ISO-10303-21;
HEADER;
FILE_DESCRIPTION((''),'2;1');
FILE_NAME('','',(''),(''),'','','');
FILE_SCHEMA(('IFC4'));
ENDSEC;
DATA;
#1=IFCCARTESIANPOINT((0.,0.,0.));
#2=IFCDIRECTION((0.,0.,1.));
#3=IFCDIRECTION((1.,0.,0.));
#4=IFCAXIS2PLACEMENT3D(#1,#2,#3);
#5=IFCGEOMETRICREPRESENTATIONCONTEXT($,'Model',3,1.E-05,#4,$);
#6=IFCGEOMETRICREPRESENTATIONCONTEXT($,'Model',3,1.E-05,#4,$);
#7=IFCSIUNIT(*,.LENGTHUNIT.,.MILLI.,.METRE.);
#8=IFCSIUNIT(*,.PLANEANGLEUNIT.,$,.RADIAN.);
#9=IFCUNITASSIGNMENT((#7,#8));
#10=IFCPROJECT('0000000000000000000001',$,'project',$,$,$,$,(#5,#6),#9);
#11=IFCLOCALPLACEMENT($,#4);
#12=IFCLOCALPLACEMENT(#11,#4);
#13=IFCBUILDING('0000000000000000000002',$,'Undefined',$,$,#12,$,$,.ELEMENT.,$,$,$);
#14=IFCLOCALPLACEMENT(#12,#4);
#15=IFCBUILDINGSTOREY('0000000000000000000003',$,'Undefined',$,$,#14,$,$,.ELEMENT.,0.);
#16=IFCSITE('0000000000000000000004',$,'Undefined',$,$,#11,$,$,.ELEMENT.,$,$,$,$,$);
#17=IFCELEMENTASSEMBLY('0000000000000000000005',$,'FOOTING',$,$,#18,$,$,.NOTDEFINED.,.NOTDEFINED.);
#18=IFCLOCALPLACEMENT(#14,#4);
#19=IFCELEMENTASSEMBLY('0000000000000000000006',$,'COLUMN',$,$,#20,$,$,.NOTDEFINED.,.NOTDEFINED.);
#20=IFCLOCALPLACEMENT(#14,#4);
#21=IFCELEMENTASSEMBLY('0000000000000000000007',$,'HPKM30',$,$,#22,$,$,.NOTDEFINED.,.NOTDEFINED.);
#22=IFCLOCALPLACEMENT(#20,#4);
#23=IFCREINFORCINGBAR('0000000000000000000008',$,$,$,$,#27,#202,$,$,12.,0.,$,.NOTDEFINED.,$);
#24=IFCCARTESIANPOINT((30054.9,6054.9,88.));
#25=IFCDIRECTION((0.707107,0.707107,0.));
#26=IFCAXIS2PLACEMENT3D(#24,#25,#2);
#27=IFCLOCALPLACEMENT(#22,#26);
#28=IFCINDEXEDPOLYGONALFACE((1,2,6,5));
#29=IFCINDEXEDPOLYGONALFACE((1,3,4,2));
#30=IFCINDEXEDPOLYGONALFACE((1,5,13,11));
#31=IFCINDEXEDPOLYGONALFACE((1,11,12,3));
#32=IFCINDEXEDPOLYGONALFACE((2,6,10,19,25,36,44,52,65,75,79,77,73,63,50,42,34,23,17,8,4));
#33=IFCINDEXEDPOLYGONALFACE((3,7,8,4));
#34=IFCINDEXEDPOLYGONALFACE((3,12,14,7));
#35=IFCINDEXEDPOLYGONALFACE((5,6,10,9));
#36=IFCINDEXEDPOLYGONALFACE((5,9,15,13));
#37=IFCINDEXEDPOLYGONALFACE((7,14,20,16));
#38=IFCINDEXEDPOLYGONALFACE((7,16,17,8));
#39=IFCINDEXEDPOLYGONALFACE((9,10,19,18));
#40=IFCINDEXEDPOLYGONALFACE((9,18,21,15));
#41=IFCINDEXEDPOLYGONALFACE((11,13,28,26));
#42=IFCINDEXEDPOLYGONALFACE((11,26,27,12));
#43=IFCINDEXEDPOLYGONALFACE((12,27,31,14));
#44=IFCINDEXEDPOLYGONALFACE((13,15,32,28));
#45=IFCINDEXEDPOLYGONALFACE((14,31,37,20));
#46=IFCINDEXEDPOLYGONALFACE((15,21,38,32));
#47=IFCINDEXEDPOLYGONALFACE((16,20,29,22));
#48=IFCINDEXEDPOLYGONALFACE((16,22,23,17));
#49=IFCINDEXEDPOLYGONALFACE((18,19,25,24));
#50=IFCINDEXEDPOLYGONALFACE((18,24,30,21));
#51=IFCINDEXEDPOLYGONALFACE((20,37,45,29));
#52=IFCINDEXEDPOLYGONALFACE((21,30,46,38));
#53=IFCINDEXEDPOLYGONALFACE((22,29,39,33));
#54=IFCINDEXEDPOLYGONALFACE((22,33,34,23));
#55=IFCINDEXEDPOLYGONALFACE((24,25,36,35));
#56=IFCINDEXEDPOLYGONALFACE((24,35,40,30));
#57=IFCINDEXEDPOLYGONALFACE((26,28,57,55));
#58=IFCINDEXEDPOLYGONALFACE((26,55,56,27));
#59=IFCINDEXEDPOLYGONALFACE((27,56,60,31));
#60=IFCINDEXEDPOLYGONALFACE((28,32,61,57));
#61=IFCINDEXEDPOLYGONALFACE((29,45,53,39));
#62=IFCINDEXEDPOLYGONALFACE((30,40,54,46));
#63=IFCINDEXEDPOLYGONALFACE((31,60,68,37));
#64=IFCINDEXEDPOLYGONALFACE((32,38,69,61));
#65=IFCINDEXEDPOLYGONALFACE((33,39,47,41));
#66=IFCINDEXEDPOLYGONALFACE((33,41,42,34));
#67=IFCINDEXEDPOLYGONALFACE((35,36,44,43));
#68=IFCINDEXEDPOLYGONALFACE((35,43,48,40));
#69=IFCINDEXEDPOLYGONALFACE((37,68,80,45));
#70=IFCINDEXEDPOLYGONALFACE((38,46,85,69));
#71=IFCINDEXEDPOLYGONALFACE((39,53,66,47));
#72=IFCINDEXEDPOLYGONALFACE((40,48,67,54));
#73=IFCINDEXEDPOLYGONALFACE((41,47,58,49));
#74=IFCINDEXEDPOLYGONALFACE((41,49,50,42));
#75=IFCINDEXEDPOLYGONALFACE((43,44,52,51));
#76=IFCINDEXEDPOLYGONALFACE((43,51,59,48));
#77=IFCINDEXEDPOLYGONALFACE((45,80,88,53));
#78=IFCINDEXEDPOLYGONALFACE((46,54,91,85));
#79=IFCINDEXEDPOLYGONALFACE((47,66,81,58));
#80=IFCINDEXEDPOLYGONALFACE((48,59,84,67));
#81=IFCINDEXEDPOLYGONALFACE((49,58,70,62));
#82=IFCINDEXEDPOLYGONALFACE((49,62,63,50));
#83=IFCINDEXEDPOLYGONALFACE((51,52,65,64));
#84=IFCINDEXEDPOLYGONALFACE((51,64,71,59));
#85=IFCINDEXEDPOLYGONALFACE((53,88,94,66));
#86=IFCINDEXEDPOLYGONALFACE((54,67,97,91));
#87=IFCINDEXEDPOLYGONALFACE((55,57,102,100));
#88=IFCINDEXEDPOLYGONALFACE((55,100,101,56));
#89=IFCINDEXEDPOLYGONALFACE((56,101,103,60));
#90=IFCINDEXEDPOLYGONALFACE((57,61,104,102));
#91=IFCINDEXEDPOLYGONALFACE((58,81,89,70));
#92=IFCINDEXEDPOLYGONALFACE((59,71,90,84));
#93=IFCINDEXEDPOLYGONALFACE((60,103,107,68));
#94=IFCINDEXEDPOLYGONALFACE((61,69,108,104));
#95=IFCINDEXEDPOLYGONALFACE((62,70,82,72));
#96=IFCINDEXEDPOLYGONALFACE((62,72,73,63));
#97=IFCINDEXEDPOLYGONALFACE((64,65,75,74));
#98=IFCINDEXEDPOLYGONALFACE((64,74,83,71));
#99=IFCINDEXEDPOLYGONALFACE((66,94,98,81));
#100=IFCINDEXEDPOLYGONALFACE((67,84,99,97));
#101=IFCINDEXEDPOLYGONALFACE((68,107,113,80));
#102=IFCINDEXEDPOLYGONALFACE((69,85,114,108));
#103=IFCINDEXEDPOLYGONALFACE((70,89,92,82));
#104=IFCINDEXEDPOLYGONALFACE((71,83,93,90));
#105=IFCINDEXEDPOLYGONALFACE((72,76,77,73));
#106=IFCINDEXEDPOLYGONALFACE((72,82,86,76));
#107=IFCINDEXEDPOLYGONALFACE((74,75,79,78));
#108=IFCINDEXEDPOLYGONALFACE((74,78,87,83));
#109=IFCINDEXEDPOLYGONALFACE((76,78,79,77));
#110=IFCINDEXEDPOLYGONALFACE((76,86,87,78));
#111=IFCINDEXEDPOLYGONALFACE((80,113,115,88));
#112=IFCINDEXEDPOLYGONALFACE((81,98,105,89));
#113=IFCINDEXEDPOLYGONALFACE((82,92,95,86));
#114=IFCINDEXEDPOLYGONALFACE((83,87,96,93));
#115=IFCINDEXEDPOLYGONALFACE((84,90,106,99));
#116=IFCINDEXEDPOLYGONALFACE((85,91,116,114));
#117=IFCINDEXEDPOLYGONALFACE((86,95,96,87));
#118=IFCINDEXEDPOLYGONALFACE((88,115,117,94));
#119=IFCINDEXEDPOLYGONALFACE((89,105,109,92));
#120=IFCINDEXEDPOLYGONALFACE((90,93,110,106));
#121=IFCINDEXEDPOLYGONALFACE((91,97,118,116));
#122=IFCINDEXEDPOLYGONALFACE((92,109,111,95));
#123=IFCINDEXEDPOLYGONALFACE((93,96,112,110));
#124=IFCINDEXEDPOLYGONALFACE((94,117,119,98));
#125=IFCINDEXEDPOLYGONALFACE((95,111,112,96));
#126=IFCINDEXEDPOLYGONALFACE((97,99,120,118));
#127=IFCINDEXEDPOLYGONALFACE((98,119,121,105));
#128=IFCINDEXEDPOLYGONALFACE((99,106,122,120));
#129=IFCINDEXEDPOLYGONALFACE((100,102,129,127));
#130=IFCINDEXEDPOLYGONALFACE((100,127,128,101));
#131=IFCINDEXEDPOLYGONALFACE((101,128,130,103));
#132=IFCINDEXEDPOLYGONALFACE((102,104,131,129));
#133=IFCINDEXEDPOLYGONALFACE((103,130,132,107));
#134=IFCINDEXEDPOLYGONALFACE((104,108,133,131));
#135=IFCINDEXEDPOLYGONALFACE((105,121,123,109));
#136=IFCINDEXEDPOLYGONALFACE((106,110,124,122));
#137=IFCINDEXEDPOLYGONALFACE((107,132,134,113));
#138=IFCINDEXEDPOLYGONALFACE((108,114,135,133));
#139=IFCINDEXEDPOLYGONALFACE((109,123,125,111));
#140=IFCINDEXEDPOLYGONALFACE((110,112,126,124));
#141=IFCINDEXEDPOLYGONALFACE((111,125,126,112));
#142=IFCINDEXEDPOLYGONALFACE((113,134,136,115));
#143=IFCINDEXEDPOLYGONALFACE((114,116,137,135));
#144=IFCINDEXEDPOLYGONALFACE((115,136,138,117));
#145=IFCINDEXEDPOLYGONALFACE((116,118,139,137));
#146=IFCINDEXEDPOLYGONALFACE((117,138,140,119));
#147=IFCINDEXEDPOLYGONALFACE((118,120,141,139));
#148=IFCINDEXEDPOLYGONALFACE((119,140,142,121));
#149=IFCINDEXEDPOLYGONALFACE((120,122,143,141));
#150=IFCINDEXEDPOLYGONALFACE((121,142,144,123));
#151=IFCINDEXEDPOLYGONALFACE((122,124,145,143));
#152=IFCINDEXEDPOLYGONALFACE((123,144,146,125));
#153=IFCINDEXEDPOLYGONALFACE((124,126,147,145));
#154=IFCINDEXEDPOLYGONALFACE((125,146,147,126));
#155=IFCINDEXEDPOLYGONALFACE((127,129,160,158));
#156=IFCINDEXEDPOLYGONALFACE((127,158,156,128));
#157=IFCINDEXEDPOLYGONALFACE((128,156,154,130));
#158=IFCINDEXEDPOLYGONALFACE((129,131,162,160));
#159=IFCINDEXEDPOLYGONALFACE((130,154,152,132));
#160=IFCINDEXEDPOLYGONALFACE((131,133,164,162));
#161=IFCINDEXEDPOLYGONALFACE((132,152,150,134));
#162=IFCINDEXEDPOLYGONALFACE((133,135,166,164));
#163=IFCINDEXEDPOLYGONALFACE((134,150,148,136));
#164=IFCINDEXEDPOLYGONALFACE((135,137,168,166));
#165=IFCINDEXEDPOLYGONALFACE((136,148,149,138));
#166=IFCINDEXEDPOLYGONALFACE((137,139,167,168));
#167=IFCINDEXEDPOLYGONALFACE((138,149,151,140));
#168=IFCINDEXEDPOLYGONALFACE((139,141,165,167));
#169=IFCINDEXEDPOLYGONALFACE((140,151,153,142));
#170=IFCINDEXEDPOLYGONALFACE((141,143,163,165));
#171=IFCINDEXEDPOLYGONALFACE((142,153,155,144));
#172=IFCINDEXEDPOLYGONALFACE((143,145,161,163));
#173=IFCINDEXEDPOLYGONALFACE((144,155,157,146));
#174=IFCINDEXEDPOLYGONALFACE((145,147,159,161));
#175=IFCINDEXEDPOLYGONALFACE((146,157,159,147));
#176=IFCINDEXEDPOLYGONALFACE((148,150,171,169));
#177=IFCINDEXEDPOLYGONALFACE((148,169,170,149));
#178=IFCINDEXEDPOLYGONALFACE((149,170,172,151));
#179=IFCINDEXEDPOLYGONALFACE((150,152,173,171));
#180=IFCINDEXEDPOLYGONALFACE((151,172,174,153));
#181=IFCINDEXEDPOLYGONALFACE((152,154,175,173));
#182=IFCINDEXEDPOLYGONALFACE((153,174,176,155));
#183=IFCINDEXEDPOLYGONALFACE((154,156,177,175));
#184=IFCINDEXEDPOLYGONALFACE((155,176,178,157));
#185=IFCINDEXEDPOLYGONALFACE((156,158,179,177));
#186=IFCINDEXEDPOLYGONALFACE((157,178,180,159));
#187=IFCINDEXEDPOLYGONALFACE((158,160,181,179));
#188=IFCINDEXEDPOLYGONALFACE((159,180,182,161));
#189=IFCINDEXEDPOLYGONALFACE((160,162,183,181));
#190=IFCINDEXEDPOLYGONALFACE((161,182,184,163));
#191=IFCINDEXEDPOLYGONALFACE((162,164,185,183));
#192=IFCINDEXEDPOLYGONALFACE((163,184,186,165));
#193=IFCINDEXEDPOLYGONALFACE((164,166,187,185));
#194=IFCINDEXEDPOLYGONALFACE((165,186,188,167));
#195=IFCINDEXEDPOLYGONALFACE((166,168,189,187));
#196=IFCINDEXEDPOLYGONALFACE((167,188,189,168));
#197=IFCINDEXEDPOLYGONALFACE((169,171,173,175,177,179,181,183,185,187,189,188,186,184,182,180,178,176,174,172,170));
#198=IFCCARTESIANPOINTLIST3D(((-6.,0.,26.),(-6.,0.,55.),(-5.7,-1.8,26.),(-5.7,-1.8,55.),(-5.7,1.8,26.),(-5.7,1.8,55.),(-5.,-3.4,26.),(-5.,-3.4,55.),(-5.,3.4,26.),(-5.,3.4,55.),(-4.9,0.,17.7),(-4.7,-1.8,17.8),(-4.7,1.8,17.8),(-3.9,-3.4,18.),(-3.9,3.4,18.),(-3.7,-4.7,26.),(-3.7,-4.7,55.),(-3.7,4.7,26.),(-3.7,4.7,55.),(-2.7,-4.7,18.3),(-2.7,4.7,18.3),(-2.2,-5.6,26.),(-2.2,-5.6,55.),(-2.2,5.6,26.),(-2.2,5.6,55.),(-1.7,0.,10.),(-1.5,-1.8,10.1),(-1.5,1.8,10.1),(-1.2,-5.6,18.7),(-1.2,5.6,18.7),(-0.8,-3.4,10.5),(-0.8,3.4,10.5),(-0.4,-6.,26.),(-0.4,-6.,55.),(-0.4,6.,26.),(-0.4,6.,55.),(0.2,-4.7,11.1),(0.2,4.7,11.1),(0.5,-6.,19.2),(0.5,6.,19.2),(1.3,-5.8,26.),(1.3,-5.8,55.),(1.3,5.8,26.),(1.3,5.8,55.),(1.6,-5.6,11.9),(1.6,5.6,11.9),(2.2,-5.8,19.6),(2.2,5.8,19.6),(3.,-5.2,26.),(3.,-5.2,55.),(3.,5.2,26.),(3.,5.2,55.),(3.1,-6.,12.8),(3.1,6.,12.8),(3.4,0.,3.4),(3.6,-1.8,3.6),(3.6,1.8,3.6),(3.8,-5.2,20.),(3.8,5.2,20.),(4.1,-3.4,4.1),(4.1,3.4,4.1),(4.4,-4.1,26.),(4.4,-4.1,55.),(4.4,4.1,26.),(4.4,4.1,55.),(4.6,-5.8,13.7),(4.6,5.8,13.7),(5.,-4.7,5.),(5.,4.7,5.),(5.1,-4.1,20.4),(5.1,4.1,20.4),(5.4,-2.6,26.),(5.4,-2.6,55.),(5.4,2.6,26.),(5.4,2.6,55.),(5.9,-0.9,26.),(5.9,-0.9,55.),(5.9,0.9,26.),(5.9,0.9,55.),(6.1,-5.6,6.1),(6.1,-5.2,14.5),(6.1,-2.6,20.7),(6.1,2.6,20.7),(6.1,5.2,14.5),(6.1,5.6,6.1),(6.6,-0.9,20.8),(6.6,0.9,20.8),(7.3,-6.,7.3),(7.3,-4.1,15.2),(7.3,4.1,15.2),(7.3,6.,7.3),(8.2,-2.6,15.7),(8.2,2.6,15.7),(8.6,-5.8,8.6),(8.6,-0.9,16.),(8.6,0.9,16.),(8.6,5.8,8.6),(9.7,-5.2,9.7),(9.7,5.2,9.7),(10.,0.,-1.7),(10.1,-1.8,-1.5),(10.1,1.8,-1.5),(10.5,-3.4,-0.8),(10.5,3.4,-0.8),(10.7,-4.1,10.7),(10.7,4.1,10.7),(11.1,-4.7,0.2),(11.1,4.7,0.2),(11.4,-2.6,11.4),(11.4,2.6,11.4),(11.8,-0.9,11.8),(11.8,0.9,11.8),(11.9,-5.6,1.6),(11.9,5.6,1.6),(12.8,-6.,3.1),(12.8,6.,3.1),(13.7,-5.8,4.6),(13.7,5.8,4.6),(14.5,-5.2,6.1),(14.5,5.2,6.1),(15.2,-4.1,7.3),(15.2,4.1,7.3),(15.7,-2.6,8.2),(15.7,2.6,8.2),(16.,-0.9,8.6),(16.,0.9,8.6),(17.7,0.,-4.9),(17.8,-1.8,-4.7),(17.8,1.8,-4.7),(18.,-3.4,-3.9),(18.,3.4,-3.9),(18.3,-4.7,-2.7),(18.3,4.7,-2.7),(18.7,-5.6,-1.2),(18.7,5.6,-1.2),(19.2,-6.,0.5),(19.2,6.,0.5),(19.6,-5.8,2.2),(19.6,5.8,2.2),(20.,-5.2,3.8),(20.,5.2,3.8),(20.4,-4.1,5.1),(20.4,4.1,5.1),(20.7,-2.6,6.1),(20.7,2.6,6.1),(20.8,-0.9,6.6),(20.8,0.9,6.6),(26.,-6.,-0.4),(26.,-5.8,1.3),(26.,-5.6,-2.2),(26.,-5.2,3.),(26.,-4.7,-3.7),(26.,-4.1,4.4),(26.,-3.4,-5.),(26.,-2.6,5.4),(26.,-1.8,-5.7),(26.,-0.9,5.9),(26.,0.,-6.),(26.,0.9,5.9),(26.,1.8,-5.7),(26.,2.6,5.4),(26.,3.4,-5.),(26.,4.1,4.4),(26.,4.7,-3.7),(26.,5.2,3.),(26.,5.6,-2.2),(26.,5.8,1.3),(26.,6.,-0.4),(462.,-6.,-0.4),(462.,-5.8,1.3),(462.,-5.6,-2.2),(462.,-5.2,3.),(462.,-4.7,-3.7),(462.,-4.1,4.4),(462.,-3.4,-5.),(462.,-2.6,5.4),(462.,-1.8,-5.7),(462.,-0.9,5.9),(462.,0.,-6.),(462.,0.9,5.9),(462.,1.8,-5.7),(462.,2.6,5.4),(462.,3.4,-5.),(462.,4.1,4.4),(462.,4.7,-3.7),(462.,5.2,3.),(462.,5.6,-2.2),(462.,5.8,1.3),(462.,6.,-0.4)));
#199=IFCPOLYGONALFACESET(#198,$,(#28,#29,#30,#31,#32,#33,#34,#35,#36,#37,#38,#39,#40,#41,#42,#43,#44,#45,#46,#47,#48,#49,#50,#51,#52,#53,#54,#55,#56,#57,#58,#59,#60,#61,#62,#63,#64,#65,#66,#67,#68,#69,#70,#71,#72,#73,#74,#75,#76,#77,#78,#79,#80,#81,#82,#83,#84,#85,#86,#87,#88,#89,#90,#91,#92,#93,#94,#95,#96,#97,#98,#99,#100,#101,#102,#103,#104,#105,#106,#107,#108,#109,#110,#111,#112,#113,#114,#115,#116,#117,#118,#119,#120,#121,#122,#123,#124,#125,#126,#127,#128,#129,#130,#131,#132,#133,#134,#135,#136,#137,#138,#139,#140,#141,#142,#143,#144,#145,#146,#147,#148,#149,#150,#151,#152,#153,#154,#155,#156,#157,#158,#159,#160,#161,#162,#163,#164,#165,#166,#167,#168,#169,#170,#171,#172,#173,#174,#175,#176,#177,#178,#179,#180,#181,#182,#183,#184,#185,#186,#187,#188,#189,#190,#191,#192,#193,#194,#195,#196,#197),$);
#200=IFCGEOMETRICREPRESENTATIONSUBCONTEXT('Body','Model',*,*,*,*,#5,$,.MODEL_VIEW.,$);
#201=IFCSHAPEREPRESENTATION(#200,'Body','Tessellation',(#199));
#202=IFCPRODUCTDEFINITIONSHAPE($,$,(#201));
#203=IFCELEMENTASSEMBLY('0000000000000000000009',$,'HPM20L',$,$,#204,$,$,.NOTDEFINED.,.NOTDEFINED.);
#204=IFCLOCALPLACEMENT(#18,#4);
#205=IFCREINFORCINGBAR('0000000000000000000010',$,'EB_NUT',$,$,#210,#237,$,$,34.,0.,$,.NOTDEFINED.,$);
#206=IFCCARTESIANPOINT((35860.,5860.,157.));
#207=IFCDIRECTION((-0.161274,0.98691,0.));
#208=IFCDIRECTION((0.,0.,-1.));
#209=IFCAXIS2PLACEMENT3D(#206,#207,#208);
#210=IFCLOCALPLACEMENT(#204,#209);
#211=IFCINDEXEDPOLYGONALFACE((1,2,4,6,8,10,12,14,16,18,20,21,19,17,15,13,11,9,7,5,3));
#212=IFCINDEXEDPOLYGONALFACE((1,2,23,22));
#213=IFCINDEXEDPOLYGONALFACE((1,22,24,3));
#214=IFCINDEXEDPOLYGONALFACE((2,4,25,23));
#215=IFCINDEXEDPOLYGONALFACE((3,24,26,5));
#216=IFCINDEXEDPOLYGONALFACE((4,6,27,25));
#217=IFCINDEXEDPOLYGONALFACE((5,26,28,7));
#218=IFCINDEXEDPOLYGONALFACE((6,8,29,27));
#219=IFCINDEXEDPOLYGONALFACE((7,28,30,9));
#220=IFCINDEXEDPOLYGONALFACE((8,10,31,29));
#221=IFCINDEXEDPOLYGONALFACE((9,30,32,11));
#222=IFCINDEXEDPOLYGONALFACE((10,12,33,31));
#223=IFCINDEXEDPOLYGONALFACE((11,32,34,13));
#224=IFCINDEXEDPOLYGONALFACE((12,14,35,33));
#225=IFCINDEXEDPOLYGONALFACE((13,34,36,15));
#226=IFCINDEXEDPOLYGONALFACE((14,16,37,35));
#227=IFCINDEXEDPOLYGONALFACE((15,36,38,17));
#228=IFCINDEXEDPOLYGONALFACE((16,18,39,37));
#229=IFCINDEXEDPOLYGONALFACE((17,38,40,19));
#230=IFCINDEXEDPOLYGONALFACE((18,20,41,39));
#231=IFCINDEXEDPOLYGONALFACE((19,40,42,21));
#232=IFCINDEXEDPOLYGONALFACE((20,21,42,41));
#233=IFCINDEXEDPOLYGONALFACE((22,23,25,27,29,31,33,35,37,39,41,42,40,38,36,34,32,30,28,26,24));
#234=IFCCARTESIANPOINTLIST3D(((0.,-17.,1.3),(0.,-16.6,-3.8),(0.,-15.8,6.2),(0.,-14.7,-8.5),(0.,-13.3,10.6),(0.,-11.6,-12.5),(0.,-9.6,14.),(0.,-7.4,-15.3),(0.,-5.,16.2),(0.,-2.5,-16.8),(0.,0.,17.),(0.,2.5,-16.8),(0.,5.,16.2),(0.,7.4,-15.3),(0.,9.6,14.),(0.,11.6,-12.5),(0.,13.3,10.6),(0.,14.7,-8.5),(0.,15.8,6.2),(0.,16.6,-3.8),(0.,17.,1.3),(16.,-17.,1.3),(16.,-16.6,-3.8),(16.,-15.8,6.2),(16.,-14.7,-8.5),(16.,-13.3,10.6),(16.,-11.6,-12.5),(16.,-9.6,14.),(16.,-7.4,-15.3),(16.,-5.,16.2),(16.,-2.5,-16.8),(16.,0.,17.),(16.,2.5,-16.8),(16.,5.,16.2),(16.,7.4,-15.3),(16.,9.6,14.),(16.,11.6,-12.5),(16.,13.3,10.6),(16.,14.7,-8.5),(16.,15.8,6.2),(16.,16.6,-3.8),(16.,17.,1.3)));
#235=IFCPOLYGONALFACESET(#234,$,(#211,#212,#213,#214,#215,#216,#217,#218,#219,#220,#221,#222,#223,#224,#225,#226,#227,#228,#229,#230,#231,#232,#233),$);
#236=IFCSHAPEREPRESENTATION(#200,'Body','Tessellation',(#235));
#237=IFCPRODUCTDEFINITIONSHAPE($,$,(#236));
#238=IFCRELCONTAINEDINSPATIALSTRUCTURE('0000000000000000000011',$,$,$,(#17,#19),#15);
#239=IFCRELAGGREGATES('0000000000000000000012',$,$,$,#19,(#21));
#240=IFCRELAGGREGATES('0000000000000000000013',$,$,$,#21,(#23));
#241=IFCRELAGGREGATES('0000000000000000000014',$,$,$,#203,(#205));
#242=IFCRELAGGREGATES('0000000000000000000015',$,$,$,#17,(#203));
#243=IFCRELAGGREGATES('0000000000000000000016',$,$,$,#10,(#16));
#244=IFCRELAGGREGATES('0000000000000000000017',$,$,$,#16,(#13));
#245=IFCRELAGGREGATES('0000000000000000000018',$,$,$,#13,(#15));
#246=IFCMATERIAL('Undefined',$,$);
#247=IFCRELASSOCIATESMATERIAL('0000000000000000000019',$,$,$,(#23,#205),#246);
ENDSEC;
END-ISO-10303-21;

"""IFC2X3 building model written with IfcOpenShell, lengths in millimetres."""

from ifc_helpers import new_model, entity, si_unit, frame, origin_with_axes, place, context, subcontext, project, spatial, source, transform, mapped, material, element, aggregate, save


model = new_model("IFC2X3")

# Units and contexts
model_context_1 = context("Model", 3, precision=1e-05, world=origin_with_axes())
model_context_2 = context("Model", 3, precision=1e-05, world=origin_with_axes())
body_context = subcontext(model_context_1, "Body", "Model", "MODEL_VIEW")
ifc_project = project(units=[si_unit("LENGTHUNIT", "METRE", prefix="MILLI"), si_unit("PLANEANGLEUNIT", "RADIAN")], contexts=[model_context_1, model_context_2])

# Site, building, storey
site_placement = place(None, origin_with_axes())
site = spatial("IfcSite", under=ifc_project, at=site_placement, Name="Undefined", CompositionType="ELEMENT")
building_placement = place(site_placement, origin_with_axes())
building = spatial("IfcBuilding", under=site, at=building_placement, Name="Undefined", CompositionType="ELEMENT")
storey_placement = place(building_placement, origin_with_axes())
storey = spatial("IfcBuildingStorey", under=building, at=storey_placement, Name="Undefined", CompositionType="ELEMENT", Elevation=0.0)

# Element assembly
assembly_1_placement = place(storey_placement, origin_with_axes())
assembly_1 = element("IfcElementAssembly", 1, at=assembly_1_placement, inside=storey, Name="FOOTING", AssemblyPlace="NOTDEFINED", PredefinedType="NOTDEFINED")

# Element assemblies
assembly_2_placement = place(storey_placement, origin_with_axes())
assembly_2 = element("IfcElementAssembly", 2, at=assembly_2_placement, inside=storey, Name="COLUMN", AssemblyPlace="NOTDEFINED", PredefinedType="NOTDEFINED")
assembly_3_placement = place(assembly_2_placement, origin_with_axes())
assembly_3 = element("IfcElementAssembly", 3, at=assembly_3_placement, Name="HPKM30", AssemblyPlace="NOTDEFINED", PredefinedType="NOTDEFINED")
aggregate(assembly_2, [assembly_3])

# Shared definitions
ifc_material_1 = material(Name="Undefined")

# Reinforcing bar
shared_shape_1 = source(origin_with_axes(), body_context, "Body", "AdvancedSweptSolid", [
    entity("IfcSweptDiskSolid", entity("IfcCompositeCurve", [entity("IfcCompositeCurveSegment", "CONTINUOUS", True, entity("IfcTrimmedCurve", entity("IfcLine", entity("IfcCartesianPoint", [0.0, 0.0, 0.0]), entity("IfcVector", entity("IfcDirection", [0.0, 0.0, -1.0]), 1.0)), [entity("IfcParameterValue", 0.0)], [entity("IfcParameterValue", 29.0)], True, "PARAMETER")), entity("IfcCompositeCurveSegment", "CONTINUOUS", True, entity("IfcTrimmedCurve", entity("IfcCircle", entity("IfcAxis2Placement3D", entity("IfcCartesianPoint", [26.0, 0.0, -29.0]), entity("IfcDirection", [0.0, -1.0, 0.0]), entity("IfcDirection", [-1.0, 0.0, 0.0])), 26.0), [entity("IfcParameterValue", 0.0)], [entity("IfcParameterValue", 1.570796)], True, "PARAMETER")), entity("IfcCompositeCurveSegment", "DISCONTINUOUS", True, entity("IfcTrimmedCurve", entity("IfcLine", entity("IfcCartesianPoint", [26.0, 0.0, -55.0]), entity("IfcVector", entity("IfcDirection", [1.0, 0.0, 0.0]), 1.0)), [entity("IfcParameterValue", 0.0)], [entity("IfcParameterValue", 436.0)], True, "PARAMETER"))], False), 6.0, None, 0.0, 466.6),
])
reinforcing_bar_1_placement = place(assembly_3_placement, frame((30054.9, 6054.9, 88.0), z_axis=(0.707107, 0.707107, 0.0), x_axis=(0.0, 0.0, 1.0)))
reinforcing_bar_1 = element("IfcReinforcingBar", 4, at=reinforcing_bar_1_placement, material=ifc_material_1, BarRole="NOTDEFINED", CrossSectionArea=0.0, NominalDiameter=12.0, context=body_context, shape_type="MappedRepresentation", body=[
    mapped(shared_shape_1, transform((0.0, 0.0, 55.0))),
])
aggregate(assembly_3, [reinforcing_bar_1])

# Element assembly, reinforcing bar
assembly_4_placement = place(assembly_1_placement, origin_with_axes())
assembly_4 = element("IfcElementAssembly", 5, at=assembly_4_placement, Name="HPM20L", AssemblyPlace="NOTDEFINED", PredefinedType="NOTDEFINED")
shared_shape_2 = source(origin_with_axes(), body_context, "Body", "AdvancedSweptSolid", [
    entity("IfcSweptDiskSolid", entity("IfcTrimmedCurve", entity("IfcLine", entity("IfcCartesianPoint", [0.0, 0.0, 0.0]), entity("IfcVector", entity("IfcDirection", [1.0, 0.0, 0.0]), 1.0)), [entity("IfcParameterValue", 0.0)], [entity("IfcParameterValue", 16.0)], True, "PARAMETER"), 17.0, None, 0.0, 16.0),
])
reinforcing_bar_2_placement = place(assembly_4_placement, frame((35860.0, 5860.0, 157.0), z_axis=(-0.161274, 0.98691, 0.0), x_axis=(0.0, 0.0, -1.0)))
reinforcing_bar_2 = element("IfcReinforcingBar", 6, at=reinforcing_bar_2_placement, material=ifc_material_1, Name="EB_NUT", BarRole="NOTDEFINED", CrossSectionArea=0.0, NominalDiameter=34.0, context=body_context, shape_type="MappedRepresentation", body=[
    mapped(shared_shape_2, transform((0.0, 0.0, 0.0))),
])
aggregate(assembly_4, [reinforcing_bar_2])

aggregate(assembly_1, [assembly_4])

save(model, "model.ifc")
